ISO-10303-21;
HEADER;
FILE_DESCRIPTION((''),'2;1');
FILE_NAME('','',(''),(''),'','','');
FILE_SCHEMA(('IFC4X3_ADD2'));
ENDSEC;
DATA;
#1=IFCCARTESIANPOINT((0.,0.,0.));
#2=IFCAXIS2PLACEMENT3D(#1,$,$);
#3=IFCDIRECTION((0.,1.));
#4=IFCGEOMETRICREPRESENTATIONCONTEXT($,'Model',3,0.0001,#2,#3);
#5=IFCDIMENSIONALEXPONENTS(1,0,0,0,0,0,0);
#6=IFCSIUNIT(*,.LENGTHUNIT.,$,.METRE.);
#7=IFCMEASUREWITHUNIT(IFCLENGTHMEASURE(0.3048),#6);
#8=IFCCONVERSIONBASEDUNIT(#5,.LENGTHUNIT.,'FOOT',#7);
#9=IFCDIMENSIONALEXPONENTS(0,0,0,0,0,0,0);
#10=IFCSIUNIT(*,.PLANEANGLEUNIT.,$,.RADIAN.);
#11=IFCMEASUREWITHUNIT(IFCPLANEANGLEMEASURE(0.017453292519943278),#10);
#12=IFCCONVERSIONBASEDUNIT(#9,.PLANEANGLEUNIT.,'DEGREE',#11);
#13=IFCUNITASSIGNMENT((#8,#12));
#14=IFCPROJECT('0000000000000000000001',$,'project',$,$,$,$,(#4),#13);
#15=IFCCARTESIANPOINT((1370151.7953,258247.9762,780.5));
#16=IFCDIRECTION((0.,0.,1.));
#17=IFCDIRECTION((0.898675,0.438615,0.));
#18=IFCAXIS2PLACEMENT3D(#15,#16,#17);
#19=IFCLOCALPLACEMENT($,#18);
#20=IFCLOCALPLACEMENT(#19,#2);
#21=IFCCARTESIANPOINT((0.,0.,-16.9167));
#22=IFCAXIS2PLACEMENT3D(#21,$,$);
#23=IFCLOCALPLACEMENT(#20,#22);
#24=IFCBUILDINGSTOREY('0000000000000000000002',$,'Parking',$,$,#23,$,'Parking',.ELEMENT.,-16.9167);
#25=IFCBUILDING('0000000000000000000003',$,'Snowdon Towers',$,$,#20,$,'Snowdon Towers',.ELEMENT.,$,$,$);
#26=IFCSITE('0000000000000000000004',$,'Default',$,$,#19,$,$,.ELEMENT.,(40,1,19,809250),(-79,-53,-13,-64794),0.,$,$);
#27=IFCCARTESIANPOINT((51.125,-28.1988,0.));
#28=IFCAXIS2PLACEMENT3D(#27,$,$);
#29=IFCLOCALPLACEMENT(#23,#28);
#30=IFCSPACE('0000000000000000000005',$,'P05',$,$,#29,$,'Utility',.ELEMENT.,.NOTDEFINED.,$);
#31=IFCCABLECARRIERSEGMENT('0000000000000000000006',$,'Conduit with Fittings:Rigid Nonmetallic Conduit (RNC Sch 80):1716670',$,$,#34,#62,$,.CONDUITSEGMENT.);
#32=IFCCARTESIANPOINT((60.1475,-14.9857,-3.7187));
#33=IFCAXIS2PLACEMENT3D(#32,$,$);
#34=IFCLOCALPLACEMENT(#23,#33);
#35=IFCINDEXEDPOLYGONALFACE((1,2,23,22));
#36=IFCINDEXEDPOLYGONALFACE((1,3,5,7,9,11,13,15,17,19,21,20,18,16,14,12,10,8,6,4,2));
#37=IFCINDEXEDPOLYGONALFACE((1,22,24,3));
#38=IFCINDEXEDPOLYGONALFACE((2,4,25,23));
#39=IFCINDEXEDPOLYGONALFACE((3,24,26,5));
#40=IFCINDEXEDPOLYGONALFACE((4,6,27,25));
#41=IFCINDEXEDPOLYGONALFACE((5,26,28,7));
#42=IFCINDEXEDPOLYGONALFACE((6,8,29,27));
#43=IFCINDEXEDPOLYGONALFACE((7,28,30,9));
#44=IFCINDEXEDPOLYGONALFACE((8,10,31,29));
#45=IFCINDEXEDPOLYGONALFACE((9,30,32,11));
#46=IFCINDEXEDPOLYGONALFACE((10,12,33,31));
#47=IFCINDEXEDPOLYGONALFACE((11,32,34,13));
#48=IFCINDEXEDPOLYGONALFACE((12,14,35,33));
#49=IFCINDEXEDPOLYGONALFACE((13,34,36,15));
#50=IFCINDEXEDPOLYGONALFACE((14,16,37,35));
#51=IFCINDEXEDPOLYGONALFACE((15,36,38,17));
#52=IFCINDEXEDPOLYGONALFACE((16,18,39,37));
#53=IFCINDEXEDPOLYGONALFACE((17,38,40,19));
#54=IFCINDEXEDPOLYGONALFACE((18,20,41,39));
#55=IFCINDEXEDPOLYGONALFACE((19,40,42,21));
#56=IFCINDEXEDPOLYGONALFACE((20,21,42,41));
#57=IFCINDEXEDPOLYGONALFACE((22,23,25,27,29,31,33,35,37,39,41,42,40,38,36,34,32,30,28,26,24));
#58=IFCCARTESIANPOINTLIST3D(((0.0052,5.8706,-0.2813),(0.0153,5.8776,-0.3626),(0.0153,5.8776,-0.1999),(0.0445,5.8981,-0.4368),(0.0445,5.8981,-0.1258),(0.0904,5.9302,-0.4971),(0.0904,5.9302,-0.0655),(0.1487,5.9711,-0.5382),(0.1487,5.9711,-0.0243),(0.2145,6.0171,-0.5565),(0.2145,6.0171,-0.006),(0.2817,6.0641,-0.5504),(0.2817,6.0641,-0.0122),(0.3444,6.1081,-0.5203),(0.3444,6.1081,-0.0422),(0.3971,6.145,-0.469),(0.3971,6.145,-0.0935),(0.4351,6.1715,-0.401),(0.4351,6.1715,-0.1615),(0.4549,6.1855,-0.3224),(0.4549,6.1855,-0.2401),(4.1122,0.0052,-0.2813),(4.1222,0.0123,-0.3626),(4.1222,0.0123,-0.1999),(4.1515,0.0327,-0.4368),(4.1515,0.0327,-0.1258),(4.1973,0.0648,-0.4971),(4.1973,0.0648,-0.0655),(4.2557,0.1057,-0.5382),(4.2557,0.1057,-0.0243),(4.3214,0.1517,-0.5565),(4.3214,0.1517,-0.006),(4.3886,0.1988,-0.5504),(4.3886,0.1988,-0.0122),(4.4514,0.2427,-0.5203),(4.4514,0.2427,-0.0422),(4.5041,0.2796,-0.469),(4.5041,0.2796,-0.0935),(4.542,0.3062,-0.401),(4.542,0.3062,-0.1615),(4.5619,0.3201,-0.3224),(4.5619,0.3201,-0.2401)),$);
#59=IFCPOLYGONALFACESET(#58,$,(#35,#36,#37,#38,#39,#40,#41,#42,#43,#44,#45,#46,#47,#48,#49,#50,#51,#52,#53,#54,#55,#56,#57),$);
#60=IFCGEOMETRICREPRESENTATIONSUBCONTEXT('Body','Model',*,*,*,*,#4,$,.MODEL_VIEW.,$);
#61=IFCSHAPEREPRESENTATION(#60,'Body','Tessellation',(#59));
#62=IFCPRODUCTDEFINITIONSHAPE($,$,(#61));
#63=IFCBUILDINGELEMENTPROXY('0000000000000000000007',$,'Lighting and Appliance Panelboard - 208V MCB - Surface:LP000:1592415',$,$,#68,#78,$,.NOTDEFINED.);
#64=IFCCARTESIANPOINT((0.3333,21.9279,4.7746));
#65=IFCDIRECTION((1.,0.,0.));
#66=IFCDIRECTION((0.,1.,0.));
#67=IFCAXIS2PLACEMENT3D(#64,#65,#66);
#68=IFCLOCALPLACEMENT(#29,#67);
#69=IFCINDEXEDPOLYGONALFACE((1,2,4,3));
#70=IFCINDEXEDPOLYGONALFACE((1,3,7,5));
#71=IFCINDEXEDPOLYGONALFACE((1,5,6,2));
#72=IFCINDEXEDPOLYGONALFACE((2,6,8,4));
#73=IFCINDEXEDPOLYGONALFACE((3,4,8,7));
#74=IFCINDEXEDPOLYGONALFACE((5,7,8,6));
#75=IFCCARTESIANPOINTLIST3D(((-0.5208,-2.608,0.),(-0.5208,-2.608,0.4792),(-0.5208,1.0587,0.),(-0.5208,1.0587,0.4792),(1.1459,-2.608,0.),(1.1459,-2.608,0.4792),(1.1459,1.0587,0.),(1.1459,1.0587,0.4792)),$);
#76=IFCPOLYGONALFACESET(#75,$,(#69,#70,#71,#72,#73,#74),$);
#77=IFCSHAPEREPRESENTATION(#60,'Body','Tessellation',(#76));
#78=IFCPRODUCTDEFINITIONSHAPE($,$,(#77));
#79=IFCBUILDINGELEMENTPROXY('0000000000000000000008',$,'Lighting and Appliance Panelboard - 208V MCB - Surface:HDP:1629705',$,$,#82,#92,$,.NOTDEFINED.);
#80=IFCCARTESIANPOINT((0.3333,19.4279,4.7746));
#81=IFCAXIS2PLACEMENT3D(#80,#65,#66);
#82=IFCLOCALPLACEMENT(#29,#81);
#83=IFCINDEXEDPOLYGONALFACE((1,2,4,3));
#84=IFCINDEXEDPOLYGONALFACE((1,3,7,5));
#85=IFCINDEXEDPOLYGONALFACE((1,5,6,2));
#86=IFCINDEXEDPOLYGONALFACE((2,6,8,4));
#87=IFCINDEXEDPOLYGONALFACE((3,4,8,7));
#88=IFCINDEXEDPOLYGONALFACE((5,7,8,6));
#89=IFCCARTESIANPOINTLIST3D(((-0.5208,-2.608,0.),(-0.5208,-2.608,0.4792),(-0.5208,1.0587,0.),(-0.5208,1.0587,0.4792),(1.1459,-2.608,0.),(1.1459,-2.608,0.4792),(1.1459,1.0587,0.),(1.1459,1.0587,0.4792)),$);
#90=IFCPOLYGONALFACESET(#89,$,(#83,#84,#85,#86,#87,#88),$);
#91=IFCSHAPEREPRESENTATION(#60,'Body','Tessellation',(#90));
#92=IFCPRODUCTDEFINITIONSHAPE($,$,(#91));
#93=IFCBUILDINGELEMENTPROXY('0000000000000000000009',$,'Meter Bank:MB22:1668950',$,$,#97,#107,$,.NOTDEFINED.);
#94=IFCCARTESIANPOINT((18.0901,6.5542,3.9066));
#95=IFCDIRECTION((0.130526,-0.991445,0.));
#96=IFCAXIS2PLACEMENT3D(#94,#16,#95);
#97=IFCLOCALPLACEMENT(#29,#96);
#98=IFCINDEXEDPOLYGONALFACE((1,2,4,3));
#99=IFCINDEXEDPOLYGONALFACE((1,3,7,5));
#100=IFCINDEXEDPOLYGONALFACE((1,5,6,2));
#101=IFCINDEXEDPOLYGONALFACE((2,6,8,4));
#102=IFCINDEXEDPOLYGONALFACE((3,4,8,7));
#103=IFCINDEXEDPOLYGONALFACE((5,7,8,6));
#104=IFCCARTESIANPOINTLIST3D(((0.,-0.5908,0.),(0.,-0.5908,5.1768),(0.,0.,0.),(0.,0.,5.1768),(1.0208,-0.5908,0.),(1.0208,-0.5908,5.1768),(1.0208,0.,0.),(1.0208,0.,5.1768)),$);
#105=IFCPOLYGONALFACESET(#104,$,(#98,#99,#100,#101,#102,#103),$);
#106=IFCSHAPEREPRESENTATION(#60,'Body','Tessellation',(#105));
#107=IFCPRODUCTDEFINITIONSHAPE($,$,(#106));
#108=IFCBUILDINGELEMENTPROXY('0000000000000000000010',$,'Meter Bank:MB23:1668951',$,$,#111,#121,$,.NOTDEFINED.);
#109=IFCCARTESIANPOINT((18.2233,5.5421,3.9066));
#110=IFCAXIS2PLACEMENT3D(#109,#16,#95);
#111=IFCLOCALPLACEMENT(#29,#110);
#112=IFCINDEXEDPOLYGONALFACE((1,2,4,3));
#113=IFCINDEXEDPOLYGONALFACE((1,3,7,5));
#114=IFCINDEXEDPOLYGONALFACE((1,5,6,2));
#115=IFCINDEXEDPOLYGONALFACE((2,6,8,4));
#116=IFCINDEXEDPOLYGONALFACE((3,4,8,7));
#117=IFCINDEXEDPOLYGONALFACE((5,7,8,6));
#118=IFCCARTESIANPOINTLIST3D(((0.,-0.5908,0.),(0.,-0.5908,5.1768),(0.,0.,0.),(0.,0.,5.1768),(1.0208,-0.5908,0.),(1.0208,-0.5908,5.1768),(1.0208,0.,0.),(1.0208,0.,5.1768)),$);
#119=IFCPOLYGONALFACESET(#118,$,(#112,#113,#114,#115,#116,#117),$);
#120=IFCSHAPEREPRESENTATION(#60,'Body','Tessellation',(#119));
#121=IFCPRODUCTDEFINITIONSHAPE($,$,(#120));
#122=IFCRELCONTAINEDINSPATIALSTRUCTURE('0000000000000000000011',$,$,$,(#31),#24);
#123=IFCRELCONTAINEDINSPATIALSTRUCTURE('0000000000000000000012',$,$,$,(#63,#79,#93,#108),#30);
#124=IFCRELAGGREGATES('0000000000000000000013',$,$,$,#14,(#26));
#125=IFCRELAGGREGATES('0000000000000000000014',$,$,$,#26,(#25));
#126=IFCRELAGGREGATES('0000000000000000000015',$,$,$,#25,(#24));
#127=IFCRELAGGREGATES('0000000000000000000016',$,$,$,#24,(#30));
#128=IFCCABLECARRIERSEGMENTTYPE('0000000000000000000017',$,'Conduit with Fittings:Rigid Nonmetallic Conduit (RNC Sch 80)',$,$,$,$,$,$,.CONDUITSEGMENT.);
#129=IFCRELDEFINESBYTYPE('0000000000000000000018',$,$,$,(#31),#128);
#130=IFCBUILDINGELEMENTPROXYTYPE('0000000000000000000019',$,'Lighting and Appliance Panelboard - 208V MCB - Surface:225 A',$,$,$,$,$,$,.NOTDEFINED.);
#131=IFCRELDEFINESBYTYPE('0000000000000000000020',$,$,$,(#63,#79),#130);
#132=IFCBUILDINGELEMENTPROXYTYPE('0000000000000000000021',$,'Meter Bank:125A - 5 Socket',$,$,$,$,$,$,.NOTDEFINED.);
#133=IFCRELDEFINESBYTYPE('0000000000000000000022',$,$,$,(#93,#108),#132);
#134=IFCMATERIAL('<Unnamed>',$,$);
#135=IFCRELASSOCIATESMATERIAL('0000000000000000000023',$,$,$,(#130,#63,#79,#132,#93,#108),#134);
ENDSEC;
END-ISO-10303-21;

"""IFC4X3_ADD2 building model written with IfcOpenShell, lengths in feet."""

from ifc_helpers import new_model, entity, si_unit, converted_unit, direction, frame, frame_2d, origin, origin_2d_with_axis, place, context, subcontext, project, spatial, rectangle, circle, extrude, source, transform, mapped, material, type_object, type_shapes, element, save


model = new_model("IFC4X3_ADD2")

# Units and contexts
model_context = context("Model", 3, precision=0.0001, world=origin(), true_north=direction((0.0, 1.0)))
body_context = subcontext(model_context, "Body", "Model", "MODEL_VIEW")
ifc_project = project(units=[converted_unit("LENGTHUNIT", "FOOT", entity("IfcLengthMeasure", 0.3048), si_unit("LENGTHUNIT", "METRE"), dimensions=[1, 0, 0, 0, 0, 0, 0]), converted_unit("PLANEANGLEUNIT", "DEGREE", entity("IfcPlaneAngleMeasure", 0.017453292519943278), si_unit("PLANEANGLEUNIT", "RADIAN"), dimensions=[0, 0, 0, 0, 0, 0, 0])], contexts=[model_context])

# Site, building, storey
site_placement = place(None, frame((1370151.7953, 258247.9762, 780.5), z_axis=(0.0, 0.0, 1.0), x_axis=(0.898675, 0.438615, 0.0)))
site = spatial("IfcSite", under=ifc_project, at=site_placement, Name="Default", CompositionType="ELEMENT", RefLatitude=(40, 1, 19, 809250), RefLongitude=(-79, -53, -13, -64794), RefElevation=0.0)
building_placement = place(site_placement, origin())
building = spatial("IfcBuilding", under=site, at=building_placement, Name="Snowdon Towers", LongName="Snowdon Towers", CompositionType="ELEMENT")
storey_placement = place(building_placement, frame((0.0, 0.0, -16.9167)))
storey = spatial("IfcBuildingStorey", under=building, at=storey_placement, Name="Parking", LongName="Parking", CompositionType="ELEMENT", Elevation=-16.9167)

# Cable carrier segment
cable_carrier_segment_type_1 = type_object("IfcCableCarrierSegmentType", Name="Conduit with Fittings:Rigid Nonmetallic Conduit (RNC Sch 80)", PredefinedType="CONDUITSEGMENT")
cable_carrier_segment_1_placement = place(storey_placement, frame((60.1475, -14.9857, -3.7187)))
element("IfcCableCarrierSegment", 1, at=cable_carrier_segment_1_placement, inside=storey, type_object=cable_carrier_segment_type_1, Name="Conduit with Fittings:Rigid Nonmetallic Conduit (RNC Sch 80):1716670", PredefinedType="CONDUITSEGMENT", context=body_context, shape_type="SweptSolid", body=[
    extrude(circle(Radius=0.276, at=frame_2d((0.0, 0.0), x_axis=(1.0, 0.0))), frame((4.3383, 0.1636, -0.2813), z_axis=(-0.573576, 0.819152, 0.0), x_axis=(-0.819152, -0.573576, 0.0)), (0.0, 0.0, 1.0), 7.1603),
])

# Shared definitions
ifc_material_1 = material(Name="<Unnamed>")

# Shared definitions
space_1_placement = place(storey_placement, frame((51.125, -28.1988, 0.0)))
space_1 = spatial("IfcSpace", under=storey, at=space_1_placement, Name="P05", LongName="Utility", CompositionType="ELEMENT", PredefinedType="NOTDEFINED")

# Building element proxies
building_element_proxy_type_1 = type_object("IfcBuildingElementProxyType", Name="Lighting and Appliance Panelboard - 208V MCB - Surface:225 A", PredefinedType="NOTDEFINED", material=ifc_material_1)
shared_shape_1 = source(origin(), body_context, "Body", "SweptSolid", [
    extrude(rectangle(XDim=1.6667, YDim=3.6667, at=origin_2d_with_axis()), frame((0.3125, -0.7746, 0.0), z_axis=(0.0, 0.0, 1.0), x_axis=(-1.0, 0.0, 0.0)), (0.0, 0.0, 1.0), 0.4792),
])
type_shapes(building_element_proxy_type_1, [shared_shape_1])
for number, where, z_axis, x_axis, name in (
    (2, (0.3333, 21.9279, 4.7746), (1.0, 0.0, 0.0), (0.0, 1.0, 0.0), "Lighting and Appliance Panelboard - 208V MCB - Surface:LP000:1592415"),
    (3, (0.3333, 19.4279, 4.7746), (1.0, 0.0, 0.0), (0.0, 1.0, 0.0), "Lighting and Appliance Panelboard - 208V MCB - Surface:HDP:1629705"),
):
    element("IfcBuildingElementProxy", number, at=place(space_1_placement, frame(where, z_axis=z_axis, x_axis=x_axis)), inside=space_1, type_object=building_element_proxy_type_1, material=ifc_material_1, Name=name, PredefinedType="NOTDEFINED", context=body_context, shape_type="MappedRepresentation", body=[
        mapped(shared_shape_1, transform((0.0, 0.0, 0.0), scale=1.0)),
    ])
building_element_proxy_type_2 = type_object("IfcBuildingElementProxyType", Name="Meter Bank:125A - 5 Socket", PredefinedType="NOTDEFINED", material=ifc_material_1)
shared_shape_2 = source(origin(), body_context, "Body", "SweptSolid", [
    extrude(rectangle(XDim=0.5908, YDim=1.0208, at=frame_2d((0.0, 0.0), x_axis=(1.0, 0.0))), frame((0.5104, -0.2954, 0.0), z_axis=(0.0, 0.0, 1.0), x_axis=(0.0, 1.0, 0.0)), (0.0, 0.0, 1.0), 5.1768),
])
type_shapes(building_element_proxy_type_2, [shared_shape_2])
for number, where, z_axis, x_axis, name in (
    (4, (18.0901, 6.5542, 3.9066), (0.0, 0.0, 1.0), (0.130526, -0.991445, 0.0), "Meter Bank:MB22:1668950"),
    (5, (18.2233, 5.5421, 3.9066), (0.0, 0.0, 1.0), (0.130526, -0.991445, 0.0), "Meter Bank:MB23:1668951"),
):
    element("IfcBuildingElementProxy", number, at=place(space_1_placement, frame(where, z_axis=z_axis, x_axis=x_axis)), inside=space_1, type_object=building_element_proxy_type_2, material=ifc_material_1, Name=name, PredefinedType="NOTDEFINED", context=body_context, shape_type="MappedRepresentation", body=[
        mapped(shared_shape_2, transform((0.0, 0.0, 0.0), scale=1.0)),
    ])

save(model, "model.ifc")
